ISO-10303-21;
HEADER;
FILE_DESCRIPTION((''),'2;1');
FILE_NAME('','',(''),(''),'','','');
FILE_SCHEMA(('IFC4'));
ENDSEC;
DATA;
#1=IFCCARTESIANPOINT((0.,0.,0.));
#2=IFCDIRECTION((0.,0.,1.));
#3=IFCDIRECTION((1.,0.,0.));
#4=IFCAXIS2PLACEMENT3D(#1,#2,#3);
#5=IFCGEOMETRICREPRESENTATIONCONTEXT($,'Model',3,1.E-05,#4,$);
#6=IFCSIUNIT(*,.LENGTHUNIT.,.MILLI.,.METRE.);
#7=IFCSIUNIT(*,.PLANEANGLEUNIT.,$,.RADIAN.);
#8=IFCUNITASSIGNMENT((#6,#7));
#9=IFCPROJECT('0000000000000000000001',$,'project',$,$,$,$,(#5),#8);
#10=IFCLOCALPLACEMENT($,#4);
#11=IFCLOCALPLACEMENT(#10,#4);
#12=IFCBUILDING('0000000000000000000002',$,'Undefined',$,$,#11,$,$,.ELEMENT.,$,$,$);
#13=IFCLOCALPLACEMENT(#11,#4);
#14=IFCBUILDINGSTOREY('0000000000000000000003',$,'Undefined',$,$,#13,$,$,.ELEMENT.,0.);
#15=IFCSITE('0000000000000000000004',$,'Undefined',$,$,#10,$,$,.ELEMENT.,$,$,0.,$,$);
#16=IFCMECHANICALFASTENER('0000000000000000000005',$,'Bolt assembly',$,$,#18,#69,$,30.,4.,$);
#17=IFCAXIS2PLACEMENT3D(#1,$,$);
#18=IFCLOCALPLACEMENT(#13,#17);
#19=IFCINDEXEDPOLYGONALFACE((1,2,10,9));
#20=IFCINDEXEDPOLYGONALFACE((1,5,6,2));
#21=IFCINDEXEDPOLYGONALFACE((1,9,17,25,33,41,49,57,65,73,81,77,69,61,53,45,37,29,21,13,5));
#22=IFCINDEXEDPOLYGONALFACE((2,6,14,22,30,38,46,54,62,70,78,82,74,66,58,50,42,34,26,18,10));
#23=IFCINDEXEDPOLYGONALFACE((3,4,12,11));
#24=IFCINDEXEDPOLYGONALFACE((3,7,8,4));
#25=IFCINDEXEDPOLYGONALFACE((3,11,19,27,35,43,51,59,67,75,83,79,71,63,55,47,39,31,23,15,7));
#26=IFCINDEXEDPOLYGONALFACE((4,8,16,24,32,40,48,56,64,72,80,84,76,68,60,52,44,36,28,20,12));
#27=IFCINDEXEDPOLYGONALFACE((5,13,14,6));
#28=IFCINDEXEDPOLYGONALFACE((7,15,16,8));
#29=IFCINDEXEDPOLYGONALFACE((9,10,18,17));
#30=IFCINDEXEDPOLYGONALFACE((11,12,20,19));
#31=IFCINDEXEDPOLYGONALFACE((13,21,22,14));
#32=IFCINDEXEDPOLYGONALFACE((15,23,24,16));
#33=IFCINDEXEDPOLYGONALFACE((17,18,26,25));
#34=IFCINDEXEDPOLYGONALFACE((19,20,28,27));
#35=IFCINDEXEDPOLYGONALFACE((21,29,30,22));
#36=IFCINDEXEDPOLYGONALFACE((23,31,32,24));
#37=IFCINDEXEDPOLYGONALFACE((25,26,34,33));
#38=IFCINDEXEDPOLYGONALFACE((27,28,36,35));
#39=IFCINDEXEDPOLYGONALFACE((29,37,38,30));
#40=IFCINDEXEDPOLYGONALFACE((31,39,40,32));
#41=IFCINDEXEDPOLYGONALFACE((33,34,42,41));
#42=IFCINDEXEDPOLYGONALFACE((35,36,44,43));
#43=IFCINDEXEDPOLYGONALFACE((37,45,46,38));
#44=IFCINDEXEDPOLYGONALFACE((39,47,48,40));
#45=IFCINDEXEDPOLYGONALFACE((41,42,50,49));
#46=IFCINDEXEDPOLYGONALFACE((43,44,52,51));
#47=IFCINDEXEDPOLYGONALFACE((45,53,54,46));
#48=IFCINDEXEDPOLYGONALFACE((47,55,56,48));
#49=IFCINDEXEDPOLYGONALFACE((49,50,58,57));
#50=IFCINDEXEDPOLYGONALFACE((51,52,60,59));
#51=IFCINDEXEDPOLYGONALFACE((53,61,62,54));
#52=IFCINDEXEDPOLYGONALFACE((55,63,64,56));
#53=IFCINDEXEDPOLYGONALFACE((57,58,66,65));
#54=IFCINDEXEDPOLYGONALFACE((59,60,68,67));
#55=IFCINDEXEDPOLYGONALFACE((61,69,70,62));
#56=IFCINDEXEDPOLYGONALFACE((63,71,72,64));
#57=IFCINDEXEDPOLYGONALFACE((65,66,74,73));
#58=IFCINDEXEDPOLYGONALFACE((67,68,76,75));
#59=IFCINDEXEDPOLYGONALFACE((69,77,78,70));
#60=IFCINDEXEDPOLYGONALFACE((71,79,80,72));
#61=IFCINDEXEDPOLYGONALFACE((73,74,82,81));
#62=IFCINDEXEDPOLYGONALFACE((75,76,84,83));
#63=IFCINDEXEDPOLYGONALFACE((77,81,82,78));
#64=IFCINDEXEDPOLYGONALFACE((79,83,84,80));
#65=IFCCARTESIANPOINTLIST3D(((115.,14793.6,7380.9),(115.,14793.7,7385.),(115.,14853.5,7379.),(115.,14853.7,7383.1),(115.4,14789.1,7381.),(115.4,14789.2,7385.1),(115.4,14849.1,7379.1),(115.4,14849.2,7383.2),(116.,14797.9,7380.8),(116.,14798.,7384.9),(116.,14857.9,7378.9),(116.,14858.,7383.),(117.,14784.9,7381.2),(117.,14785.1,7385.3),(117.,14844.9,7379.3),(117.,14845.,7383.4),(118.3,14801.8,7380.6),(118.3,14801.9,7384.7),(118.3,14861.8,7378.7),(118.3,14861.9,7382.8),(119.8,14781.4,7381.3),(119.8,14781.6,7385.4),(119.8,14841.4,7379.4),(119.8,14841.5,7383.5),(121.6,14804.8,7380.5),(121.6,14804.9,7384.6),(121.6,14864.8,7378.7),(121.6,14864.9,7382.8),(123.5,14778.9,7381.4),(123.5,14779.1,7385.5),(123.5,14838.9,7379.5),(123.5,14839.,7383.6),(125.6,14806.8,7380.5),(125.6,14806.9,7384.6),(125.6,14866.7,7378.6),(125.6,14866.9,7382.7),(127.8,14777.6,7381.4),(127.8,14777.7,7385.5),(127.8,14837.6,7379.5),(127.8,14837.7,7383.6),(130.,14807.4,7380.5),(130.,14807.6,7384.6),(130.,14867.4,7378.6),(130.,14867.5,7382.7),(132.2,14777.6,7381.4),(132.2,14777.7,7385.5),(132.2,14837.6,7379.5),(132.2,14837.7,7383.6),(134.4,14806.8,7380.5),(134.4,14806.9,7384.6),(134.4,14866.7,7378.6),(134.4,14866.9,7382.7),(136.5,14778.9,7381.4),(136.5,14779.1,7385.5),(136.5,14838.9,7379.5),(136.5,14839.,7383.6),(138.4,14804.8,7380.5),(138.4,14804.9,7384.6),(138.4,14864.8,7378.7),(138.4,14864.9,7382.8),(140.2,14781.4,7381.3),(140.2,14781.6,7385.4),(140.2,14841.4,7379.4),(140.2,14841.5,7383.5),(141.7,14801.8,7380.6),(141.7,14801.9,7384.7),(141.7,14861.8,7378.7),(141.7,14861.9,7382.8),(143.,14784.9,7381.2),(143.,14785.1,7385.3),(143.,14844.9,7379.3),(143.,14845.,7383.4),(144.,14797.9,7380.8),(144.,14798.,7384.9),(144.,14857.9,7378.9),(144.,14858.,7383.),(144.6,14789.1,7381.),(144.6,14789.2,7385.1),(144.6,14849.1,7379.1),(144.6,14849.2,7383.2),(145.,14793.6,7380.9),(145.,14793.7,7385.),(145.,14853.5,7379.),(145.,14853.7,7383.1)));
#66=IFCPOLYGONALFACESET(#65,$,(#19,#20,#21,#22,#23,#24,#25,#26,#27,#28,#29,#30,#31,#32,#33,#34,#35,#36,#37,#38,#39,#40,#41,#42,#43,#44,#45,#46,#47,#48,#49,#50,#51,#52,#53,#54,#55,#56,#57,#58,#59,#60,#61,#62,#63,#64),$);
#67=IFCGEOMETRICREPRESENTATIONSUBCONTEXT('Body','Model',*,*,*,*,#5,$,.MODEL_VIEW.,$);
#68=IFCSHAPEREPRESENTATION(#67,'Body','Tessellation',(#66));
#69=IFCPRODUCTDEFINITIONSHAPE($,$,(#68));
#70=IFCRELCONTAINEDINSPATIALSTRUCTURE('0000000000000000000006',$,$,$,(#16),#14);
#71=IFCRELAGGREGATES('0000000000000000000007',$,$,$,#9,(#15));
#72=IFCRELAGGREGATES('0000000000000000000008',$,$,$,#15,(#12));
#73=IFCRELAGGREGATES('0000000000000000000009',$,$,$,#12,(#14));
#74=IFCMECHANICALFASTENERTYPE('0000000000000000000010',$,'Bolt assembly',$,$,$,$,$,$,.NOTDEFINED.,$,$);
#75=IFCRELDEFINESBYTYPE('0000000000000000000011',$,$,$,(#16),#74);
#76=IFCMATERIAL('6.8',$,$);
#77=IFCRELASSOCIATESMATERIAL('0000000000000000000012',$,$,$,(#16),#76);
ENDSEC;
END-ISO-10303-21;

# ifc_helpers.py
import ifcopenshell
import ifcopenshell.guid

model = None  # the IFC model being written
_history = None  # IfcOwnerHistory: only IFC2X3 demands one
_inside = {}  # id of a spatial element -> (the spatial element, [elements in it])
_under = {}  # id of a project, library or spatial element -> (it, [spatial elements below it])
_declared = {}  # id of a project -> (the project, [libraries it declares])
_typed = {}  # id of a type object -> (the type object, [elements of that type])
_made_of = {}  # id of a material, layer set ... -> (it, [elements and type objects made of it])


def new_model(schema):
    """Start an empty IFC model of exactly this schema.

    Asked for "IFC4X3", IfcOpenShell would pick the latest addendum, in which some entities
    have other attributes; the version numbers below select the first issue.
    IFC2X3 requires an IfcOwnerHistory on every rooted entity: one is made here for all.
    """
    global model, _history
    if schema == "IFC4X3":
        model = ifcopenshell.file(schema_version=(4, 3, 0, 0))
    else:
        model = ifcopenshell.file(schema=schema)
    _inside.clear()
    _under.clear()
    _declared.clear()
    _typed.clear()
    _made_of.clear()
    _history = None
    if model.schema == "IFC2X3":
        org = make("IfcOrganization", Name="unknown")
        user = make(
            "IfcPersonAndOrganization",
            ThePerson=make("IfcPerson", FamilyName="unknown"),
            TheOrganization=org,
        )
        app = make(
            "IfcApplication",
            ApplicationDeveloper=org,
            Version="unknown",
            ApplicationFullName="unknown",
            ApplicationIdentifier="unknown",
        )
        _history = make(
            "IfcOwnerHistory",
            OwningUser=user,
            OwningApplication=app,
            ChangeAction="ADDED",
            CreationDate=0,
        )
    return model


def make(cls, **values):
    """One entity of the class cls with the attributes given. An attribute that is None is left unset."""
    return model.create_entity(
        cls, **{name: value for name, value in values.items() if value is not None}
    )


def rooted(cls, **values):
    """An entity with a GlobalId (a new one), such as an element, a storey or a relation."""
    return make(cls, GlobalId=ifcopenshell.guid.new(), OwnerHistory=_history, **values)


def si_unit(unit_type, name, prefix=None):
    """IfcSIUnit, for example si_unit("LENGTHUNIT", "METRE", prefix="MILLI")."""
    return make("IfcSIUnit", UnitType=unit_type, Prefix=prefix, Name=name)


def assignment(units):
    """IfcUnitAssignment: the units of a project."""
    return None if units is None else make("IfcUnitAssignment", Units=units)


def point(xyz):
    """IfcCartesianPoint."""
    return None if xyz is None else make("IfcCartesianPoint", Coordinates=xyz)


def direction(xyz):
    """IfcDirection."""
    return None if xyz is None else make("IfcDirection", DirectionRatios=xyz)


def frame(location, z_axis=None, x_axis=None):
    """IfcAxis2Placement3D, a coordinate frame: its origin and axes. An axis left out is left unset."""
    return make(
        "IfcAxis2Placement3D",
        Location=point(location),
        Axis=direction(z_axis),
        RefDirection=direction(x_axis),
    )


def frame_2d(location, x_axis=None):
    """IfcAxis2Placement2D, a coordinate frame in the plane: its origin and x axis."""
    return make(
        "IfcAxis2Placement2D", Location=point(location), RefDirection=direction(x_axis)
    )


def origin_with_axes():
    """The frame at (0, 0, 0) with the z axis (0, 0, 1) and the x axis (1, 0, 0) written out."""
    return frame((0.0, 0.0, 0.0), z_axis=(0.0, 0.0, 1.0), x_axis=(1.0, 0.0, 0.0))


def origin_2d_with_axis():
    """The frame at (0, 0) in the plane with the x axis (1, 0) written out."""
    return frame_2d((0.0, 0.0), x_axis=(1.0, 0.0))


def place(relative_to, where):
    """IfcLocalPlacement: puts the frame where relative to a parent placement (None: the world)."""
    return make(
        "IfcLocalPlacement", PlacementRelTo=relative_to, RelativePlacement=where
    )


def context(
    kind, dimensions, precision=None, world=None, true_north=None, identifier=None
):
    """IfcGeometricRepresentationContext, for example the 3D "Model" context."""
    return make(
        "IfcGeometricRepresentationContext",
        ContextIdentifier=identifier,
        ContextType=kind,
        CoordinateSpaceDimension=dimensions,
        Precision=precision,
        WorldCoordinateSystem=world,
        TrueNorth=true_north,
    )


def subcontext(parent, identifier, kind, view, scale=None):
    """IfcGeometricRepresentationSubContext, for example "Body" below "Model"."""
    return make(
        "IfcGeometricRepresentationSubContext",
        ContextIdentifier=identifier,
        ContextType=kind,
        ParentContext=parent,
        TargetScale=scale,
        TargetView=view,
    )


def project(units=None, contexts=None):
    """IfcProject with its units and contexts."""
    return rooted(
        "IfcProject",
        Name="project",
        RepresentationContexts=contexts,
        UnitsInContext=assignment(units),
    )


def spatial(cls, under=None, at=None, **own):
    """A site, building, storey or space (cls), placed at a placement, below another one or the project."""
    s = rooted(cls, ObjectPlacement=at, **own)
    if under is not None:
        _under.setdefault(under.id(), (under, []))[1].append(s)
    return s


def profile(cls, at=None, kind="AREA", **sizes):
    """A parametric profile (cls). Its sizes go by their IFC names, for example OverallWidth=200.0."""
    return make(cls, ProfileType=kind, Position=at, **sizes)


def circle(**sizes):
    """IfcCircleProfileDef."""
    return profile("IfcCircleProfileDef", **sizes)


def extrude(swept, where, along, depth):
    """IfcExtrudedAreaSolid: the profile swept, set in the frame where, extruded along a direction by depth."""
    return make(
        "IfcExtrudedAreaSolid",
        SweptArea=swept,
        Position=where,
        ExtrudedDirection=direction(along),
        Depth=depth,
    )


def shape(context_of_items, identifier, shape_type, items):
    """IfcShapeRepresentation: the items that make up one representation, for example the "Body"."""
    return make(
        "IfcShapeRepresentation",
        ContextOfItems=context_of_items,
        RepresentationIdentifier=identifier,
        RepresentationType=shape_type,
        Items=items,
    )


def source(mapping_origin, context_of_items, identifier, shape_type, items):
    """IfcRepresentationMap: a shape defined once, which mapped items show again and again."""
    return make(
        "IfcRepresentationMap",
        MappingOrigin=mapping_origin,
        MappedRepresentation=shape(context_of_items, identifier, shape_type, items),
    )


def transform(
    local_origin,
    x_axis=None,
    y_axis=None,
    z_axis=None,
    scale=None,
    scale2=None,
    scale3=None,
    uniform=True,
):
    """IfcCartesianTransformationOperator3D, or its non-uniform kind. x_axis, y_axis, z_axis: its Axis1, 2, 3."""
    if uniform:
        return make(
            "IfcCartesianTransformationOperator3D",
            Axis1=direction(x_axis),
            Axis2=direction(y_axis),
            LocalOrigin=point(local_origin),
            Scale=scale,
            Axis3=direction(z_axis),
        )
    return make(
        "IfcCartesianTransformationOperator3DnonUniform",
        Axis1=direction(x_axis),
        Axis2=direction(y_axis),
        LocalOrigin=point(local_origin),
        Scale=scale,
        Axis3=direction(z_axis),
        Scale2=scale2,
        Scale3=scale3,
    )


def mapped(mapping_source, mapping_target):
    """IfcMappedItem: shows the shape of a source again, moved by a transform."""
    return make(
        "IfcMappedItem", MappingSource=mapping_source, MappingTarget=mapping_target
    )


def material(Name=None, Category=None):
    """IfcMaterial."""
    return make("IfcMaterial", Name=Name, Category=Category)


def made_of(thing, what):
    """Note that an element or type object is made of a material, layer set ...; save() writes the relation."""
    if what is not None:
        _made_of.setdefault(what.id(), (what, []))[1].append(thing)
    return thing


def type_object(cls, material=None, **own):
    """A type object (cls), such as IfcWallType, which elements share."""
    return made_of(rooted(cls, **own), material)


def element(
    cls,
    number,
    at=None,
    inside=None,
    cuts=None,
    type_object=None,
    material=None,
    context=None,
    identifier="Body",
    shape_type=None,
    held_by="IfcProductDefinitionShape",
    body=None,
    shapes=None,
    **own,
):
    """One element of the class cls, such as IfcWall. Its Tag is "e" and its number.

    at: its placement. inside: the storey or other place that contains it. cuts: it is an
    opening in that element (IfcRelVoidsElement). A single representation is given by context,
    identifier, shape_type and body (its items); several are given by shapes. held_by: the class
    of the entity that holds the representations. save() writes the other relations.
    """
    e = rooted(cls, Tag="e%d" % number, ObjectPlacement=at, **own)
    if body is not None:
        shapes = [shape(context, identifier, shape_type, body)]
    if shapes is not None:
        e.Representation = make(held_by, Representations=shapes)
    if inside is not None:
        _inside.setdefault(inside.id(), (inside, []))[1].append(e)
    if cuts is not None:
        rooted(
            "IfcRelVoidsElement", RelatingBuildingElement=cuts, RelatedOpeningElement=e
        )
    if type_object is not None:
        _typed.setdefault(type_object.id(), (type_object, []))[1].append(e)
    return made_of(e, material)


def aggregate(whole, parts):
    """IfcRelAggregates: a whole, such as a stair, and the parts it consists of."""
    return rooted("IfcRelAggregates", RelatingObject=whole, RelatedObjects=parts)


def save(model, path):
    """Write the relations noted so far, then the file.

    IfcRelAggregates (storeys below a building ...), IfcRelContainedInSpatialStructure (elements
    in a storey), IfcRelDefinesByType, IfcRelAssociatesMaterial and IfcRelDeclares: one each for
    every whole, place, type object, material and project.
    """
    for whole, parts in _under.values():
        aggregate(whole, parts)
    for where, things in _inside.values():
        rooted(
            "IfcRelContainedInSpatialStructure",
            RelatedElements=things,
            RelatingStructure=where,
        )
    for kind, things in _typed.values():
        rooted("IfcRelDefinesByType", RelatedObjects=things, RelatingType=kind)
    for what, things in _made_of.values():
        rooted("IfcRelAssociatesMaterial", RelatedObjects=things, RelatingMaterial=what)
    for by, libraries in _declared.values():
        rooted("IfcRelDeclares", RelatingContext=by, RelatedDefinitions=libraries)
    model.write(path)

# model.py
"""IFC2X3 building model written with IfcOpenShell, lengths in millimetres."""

from ifc_helpers import new_model, si_unit, frame, origin_with_axes, origin_2d_with_axis, place, context, subcontext, project, spatial, circle, extrude, source, transform, mapped, material, type_object, element, save


model = new_model("IFC2X3")

# Units and contexts
model_context = context("Model", 3, precision=1e-05, world=origin_with_axes())
body_context = subcontext(model_context, "Body", "Model", "MODEL_VIEW")
ifc_project = project(units=[si_unit("LENGTHUNIT", "METRE", prefix="MILLI"), si_unit("PLANEANGLEUNIT", "RADIAN")], contexts=[model_context])

# Site, building, storey
site_placement = place(None, origin_with_axes())
site = spatial("IfcSite", under=ifc_project, at=site_placement, Name="Undefined", CompositionType="ELEMENT", RefElevation=0.0)
building_placement = place(site_placement, origin_with_axes())
building = spatial("IfcBuilding", under=site, at=building_placement, Name="Undefined", CompositionType="ELEMENT")
storey_placement = place(building_placement, origin_with_axes())
storey = spatial("IfcBuildingStorey", under=building, at=storey_placement, Name="Undefined", CompositionType="ELEMENT", Elevation=0.0)

# Mechanical fastener
ifc_material_1 = material(Name="6.8")
mechanical_fastener_type = type_object("IfcMechanicalFastenerType", Name="Bolt assembly")
shared_shape_1 = source(origin_with_axes(), body_context, "Body", "SweptSolid", [
    extrude(circle(Radius=15.0, at=origin_2d_with_axis()), frame((0.0, 0.0, 0.0), z_axis=(0.0, 1.0, 0.0), x_axis=(1.0, 0.0, 0.0)), (0.0, 0.0, 1.0), 4.1),
])
mechanical_fastener_1_placement = place(storey_placement, frame((130.0, 14792.6, 7385.0), z_axis=(-1.0, 0.0, 0.0), x_axis=(0.0, 0.999507, -0.031411)))
element("IfcMechanicalFastener", 1, at=mechanical_fastener_1_placement, inside=storey, type_object=mechanical_fastener_type, material=ifc_material_1, Name="Bolt assembly", NominalDiameter=30.0, NominalLength=4.0, context=body_context, shape_type="MappedRepresentation", body=[
    mapped(shared_shape_1, transform((0.0, 0.0, 0.0))),
    mapped(shared_shape_1, transform((60.0, 0.0, 0.0))),
])

save(model, "model.ifc")
